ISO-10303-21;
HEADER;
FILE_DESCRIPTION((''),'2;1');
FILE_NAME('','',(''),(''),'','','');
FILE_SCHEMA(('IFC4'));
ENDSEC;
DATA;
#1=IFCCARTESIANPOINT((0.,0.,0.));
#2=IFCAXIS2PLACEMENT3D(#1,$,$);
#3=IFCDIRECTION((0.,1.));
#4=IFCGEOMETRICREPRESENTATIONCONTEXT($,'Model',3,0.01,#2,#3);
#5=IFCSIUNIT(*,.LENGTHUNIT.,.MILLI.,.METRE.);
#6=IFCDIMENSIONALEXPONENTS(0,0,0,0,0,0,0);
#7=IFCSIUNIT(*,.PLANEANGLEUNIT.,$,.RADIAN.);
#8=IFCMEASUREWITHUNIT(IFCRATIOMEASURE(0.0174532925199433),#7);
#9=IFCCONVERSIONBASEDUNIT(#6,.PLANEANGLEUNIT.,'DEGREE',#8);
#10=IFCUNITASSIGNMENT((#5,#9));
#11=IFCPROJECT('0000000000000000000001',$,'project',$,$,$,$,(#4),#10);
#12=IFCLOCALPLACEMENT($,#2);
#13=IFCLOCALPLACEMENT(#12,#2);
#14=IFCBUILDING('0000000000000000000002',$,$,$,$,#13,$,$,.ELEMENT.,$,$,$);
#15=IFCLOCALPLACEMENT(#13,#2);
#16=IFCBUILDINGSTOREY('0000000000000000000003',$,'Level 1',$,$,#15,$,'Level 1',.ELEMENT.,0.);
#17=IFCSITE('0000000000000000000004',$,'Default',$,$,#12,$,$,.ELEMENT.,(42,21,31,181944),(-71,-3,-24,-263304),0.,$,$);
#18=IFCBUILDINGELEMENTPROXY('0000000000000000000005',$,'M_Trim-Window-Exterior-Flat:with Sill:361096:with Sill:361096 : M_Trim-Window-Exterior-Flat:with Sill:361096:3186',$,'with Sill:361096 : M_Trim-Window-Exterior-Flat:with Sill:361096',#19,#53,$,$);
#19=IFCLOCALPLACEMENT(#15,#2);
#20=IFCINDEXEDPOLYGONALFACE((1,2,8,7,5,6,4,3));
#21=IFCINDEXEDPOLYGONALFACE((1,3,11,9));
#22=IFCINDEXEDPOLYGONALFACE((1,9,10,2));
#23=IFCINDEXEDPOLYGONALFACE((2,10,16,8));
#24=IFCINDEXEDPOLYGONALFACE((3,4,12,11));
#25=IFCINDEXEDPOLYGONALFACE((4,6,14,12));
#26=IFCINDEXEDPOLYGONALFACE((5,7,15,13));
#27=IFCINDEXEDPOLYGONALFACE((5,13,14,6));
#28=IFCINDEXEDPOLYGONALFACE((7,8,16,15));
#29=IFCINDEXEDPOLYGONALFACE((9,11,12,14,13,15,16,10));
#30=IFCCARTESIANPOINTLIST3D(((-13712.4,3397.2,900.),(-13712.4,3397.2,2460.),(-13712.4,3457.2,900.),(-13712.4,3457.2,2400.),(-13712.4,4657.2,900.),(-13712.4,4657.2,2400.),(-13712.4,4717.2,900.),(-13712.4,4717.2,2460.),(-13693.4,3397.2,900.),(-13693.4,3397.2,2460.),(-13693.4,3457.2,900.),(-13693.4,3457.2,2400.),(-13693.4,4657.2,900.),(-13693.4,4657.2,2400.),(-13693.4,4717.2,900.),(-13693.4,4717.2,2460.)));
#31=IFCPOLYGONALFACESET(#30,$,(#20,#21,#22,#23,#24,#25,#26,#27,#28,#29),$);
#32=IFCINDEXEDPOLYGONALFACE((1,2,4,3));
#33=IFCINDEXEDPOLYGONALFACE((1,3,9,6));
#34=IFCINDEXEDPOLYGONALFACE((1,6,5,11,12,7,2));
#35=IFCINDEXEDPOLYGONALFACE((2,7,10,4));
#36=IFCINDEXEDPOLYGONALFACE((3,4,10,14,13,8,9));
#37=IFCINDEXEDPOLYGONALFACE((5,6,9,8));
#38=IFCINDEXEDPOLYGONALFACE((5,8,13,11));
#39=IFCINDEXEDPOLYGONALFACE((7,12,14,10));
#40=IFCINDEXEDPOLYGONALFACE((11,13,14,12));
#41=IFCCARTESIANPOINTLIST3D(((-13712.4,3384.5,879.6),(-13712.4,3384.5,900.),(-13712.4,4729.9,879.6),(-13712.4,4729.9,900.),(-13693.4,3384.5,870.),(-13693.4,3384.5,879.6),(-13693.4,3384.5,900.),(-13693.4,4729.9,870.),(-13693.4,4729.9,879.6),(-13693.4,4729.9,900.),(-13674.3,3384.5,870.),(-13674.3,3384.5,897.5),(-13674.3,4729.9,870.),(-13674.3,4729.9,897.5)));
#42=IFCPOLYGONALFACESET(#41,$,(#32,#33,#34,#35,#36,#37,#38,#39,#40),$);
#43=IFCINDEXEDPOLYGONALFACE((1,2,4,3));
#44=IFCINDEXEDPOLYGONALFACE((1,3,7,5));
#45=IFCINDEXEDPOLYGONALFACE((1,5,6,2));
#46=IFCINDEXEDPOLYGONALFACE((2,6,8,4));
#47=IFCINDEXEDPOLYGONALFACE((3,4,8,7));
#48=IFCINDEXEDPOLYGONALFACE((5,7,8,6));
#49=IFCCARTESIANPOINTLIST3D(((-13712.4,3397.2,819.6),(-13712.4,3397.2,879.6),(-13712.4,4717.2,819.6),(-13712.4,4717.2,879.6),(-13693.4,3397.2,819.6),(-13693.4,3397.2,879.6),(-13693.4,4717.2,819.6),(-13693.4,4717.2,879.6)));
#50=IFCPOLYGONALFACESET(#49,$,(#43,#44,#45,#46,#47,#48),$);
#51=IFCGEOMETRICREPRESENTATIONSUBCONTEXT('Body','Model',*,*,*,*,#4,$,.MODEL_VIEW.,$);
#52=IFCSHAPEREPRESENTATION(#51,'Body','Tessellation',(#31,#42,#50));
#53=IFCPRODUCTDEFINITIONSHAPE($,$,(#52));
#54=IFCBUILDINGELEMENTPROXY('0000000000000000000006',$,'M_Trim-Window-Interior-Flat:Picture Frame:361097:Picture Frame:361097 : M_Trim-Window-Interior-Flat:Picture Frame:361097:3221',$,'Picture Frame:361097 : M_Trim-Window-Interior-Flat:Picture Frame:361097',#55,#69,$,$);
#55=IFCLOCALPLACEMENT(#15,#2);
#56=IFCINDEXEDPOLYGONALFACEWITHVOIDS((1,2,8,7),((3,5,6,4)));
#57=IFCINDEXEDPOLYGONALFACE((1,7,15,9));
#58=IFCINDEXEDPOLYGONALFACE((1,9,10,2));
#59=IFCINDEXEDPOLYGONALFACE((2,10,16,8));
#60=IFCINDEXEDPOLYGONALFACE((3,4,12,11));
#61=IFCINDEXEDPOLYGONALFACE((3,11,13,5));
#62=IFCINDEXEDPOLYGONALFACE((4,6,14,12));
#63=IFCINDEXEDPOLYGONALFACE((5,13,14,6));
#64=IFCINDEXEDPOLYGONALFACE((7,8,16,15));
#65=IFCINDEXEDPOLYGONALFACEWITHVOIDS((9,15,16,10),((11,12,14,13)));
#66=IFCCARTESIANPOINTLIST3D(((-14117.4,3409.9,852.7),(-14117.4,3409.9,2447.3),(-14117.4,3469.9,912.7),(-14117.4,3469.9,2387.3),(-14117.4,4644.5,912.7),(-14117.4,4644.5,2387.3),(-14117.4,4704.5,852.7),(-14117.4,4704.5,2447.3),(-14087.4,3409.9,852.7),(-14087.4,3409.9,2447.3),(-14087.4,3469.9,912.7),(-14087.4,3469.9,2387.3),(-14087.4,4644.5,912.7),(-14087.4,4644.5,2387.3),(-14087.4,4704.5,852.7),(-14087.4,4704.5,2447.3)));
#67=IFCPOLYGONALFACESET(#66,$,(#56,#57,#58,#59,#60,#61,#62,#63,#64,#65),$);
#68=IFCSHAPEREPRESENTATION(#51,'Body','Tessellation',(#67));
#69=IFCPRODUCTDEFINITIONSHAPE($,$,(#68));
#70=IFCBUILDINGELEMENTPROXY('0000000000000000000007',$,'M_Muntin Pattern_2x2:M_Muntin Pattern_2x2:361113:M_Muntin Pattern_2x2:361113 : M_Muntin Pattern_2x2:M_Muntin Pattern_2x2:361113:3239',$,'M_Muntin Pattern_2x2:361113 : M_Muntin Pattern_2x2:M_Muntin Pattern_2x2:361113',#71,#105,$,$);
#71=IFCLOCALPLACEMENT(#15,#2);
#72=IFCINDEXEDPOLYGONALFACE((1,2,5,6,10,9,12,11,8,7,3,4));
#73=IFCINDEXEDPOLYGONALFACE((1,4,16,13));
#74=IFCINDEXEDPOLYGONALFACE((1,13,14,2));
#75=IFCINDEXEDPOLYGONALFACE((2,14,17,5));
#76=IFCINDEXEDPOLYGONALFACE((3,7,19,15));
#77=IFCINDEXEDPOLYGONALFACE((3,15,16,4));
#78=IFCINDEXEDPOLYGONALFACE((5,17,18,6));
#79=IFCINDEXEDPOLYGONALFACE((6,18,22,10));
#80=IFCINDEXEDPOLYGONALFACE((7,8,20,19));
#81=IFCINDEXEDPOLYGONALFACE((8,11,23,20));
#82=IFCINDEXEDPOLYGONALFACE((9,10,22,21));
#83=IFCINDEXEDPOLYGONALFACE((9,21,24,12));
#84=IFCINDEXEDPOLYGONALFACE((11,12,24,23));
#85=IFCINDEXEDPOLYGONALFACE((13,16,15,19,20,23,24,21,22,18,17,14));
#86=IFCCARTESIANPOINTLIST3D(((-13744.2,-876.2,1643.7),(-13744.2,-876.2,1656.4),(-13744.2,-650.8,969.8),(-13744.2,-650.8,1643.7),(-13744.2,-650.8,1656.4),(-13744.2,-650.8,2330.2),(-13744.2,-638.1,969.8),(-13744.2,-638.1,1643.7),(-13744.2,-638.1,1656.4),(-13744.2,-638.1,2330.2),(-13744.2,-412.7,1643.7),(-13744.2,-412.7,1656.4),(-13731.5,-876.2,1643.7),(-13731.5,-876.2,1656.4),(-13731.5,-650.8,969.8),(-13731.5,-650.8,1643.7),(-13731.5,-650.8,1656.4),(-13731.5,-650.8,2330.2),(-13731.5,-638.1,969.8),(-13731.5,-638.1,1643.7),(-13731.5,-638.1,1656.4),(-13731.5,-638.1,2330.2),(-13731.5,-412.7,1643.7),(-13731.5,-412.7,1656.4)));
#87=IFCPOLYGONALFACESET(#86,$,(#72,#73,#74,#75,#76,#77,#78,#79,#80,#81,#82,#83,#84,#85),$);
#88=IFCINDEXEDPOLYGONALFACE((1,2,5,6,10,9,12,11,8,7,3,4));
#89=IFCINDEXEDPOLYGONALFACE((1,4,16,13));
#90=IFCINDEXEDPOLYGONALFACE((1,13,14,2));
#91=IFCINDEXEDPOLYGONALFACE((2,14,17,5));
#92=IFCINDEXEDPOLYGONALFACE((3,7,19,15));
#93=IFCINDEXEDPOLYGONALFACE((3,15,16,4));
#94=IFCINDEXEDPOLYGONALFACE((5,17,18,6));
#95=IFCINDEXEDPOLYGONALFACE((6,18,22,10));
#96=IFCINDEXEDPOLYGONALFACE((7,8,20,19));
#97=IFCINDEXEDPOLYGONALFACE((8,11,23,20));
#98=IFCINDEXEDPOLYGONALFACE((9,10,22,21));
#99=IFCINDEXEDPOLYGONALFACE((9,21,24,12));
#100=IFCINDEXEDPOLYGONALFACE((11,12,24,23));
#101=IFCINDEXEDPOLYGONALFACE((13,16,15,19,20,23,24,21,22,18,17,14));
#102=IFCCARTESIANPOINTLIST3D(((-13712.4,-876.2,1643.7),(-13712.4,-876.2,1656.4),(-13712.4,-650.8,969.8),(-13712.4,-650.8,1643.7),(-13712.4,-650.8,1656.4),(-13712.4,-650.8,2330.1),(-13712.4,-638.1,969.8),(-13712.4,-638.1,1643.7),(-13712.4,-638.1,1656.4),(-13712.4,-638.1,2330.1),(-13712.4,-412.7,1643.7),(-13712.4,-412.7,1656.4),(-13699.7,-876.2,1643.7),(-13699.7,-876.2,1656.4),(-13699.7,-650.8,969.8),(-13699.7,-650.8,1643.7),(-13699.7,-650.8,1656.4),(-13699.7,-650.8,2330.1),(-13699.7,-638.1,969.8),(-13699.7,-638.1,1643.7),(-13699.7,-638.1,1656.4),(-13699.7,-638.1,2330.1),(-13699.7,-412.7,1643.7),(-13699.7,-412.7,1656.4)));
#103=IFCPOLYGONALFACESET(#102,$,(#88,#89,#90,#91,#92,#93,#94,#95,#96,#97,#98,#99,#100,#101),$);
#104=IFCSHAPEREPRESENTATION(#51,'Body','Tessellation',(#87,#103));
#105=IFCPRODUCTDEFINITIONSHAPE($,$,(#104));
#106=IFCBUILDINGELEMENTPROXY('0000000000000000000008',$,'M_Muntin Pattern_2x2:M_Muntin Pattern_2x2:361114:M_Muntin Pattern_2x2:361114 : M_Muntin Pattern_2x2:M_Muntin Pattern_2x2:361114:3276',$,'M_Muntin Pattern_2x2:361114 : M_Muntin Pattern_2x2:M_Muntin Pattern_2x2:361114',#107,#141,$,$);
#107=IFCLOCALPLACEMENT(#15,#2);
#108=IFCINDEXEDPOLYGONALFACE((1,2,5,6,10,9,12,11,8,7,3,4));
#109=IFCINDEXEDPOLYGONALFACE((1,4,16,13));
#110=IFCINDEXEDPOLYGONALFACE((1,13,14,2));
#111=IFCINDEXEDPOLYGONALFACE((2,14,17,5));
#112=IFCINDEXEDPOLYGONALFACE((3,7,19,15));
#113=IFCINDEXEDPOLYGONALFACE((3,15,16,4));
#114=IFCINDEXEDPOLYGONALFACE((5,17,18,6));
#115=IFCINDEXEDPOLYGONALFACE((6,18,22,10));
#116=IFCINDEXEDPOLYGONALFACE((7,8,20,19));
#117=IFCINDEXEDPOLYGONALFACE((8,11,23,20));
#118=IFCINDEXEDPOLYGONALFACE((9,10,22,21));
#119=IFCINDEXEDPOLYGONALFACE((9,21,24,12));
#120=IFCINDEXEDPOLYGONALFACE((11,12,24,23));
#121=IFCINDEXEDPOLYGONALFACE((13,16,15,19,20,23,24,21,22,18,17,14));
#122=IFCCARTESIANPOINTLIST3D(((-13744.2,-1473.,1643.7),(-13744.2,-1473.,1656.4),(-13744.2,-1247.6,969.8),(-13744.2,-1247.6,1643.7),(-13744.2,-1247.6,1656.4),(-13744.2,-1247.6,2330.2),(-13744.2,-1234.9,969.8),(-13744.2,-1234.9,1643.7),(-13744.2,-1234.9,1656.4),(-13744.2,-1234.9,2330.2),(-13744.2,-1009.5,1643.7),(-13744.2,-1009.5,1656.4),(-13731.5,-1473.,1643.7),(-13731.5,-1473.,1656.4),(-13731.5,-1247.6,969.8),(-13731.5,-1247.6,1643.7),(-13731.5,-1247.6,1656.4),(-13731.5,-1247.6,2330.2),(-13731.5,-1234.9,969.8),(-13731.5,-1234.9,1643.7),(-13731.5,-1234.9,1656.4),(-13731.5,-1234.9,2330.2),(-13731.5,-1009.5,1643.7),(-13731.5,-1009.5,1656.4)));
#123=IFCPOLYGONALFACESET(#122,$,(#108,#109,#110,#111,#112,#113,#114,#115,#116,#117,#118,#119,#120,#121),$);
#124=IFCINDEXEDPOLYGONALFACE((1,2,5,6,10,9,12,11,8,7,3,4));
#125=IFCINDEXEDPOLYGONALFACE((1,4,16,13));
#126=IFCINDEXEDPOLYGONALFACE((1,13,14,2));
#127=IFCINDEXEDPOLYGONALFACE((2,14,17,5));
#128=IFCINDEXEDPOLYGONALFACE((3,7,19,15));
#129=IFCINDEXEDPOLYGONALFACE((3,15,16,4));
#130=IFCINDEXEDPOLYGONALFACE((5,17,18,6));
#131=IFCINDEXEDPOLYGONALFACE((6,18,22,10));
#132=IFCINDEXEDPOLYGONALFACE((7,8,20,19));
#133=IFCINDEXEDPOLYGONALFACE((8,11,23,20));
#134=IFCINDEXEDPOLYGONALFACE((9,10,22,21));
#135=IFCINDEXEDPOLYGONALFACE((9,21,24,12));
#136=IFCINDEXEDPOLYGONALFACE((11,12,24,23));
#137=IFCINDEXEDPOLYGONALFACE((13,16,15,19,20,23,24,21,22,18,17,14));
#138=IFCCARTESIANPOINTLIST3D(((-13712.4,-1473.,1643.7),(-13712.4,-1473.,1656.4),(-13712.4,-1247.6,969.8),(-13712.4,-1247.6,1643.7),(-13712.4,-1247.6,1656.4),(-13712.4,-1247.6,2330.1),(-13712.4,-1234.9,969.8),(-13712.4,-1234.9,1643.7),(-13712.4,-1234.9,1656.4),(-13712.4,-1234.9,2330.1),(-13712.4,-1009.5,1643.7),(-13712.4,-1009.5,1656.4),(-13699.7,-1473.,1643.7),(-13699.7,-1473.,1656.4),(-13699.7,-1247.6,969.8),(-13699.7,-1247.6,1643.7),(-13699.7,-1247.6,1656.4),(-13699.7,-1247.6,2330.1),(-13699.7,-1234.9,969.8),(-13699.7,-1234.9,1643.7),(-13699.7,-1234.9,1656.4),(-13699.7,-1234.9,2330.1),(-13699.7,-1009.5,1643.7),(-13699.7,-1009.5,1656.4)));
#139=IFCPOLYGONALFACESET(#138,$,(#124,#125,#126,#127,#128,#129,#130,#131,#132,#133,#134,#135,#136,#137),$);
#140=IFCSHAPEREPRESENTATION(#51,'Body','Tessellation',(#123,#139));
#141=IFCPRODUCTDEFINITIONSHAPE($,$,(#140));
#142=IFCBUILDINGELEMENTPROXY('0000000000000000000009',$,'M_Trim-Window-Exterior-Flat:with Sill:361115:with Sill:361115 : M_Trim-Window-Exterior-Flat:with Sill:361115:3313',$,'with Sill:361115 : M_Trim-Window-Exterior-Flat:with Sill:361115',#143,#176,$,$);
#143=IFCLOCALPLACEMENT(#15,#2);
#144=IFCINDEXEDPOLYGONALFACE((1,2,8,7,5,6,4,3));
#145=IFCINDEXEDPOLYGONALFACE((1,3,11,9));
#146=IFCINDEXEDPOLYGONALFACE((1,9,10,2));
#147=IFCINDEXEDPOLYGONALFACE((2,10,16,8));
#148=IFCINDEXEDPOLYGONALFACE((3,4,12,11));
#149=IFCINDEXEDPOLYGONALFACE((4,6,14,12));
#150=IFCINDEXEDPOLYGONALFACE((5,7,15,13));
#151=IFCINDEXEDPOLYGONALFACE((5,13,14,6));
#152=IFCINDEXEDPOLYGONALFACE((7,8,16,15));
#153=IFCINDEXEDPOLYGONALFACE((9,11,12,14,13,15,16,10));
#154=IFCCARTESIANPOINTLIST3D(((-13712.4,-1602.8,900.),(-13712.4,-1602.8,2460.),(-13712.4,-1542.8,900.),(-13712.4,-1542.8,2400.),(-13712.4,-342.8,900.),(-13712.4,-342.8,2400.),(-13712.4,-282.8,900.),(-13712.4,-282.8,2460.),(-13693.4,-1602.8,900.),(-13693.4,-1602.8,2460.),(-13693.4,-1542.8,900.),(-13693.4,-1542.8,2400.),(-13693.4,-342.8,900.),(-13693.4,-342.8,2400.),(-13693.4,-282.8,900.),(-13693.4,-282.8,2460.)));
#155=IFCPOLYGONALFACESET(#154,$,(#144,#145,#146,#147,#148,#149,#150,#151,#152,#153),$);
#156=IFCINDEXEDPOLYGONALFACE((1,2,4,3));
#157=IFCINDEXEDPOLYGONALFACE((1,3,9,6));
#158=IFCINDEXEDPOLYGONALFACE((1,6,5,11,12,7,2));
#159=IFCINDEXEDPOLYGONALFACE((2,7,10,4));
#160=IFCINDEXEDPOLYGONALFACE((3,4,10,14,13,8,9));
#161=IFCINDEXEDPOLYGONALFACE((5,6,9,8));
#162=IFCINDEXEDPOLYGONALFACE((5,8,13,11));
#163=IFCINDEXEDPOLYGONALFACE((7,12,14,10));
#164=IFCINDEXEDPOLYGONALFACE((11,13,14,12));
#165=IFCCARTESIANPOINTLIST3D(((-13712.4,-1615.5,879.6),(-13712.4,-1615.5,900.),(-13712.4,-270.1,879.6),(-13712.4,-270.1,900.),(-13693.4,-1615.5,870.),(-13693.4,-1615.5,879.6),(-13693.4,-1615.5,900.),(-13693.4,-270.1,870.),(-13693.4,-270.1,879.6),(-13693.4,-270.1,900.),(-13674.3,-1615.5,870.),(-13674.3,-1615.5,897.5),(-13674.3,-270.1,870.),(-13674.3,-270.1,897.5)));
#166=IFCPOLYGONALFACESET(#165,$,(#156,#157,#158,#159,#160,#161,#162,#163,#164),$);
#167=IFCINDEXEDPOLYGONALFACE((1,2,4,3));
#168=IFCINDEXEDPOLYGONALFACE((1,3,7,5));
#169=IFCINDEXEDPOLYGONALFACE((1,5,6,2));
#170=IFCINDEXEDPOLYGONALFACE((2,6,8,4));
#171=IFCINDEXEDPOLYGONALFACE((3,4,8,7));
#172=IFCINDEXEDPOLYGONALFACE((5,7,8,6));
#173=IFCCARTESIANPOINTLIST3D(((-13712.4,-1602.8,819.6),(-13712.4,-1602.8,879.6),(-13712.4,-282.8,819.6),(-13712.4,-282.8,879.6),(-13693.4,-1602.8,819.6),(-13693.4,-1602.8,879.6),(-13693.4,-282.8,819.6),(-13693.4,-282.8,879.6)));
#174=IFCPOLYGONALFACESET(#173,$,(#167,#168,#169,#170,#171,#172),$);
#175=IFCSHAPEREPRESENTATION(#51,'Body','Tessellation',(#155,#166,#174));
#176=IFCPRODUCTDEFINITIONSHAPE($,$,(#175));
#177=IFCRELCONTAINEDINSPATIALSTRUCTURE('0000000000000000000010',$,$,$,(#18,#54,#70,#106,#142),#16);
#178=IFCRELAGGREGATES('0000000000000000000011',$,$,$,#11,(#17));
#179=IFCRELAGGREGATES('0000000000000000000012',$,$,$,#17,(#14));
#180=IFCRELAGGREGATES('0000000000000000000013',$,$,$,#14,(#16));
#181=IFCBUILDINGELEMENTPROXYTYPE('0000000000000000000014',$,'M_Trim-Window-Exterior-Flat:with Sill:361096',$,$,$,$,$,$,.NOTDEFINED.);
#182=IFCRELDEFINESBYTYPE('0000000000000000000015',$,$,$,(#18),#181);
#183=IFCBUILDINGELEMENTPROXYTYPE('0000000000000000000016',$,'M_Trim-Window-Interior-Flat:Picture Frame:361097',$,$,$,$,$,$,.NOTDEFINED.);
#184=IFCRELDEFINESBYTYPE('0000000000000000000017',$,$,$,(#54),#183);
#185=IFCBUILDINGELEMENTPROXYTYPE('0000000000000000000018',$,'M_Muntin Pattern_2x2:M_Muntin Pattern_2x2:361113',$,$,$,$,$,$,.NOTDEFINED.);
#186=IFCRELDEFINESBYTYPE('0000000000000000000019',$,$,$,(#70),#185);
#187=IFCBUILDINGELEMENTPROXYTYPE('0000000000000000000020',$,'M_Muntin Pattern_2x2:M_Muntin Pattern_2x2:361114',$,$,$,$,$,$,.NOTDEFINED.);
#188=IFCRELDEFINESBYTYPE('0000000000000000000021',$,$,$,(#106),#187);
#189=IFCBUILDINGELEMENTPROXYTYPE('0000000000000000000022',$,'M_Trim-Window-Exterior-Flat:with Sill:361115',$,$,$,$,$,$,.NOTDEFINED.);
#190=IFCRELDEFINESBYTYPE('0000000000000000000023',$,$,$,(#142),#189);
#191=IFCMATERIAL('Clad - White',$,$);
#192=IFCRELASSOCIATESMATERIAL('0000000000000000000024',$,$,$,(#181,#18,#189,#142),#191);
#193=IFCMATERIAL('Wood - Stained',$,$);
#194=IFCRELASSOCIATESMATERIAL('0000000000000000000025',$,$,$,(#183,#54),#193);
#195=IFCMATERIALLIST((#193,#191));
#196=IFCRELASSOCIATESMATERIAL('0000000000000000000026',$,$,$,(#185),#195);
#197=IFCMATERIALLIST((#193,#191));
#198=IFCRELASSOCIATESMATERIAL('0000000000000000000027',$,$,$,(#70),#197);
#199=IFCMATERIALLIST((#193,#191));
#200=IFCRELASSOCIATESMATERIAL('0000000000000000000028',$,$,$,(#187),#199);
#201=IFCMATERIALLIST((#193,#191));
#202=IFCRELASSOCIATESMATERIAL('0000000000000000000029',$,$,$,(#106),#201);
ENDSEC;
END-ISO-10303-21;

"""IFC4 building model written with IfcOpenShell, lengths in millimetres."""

from ifc_helpers import new_model, entity, si_unit, converted_unit, direction, frame, frame_2d, origin, origin_2d_with_axis, place, context, subcontext, project, spatial, polyline, rectangle, outline, extrude, source, transform, mapped, material, material_list, type_object, type_shapes, element, save


model = new_model("IFC4")

# Units and contexts
model_context = context("Model", 3, precision=0.01, world=origin(), true_north=direction((0.0, 1.0)))
body_context = subcontext(model_context, "Body", "Model", "MODEL_VIEW")
ifc_project = project(units=[si_unit("LENGTHUNIT", "METRE", prefix="MILLI"), converted_unit("PLANEANGLEUNIT", "DEGREE", entity("IfcRatioMeasure", 0.0174532925199433), si_unit("PLANEANGLEUNIT", "RADIAN"), dimensions=[0, 0, 0, 0, 0, 0, 0])], contexts=[model_context])

# Site, building, storey
site_placement = place(None, origin())
site = spatial("IfcSite", under=ifc_project, at=site_placement, Name="Default", CompositionType="ELEMENT", RefLatitude=(42, 21, 31, 181944), RefLongitude=(-71, -3, -24, -263304), RefElevation=0.0)
building_placement = place(site_placement, origin())
building = spatial("IfcBuilding", under=site, at=building_placement, CompositionType="ELEMENT")
storey_placement = place(building_placement, origin())
storey = spatial("IfcBuildingStorey", under=building, at=storey_placement, Name="Level 1", LongName="Level 1", CompositionType="ELEMENT", Elevation=0.0)

# Building element proxies
ifc_material_1 = material(Name="Wood - Stained")
ifc_material_2 = material(Name="Clad - White")
building_element_proxy_type_1 = type_object("IfcBuildingElementProxyType", Name="M_Trim-Window-Exterior-Flat:with Sill:361096", PredefinedType="NOTDEFINED", material=ifc_material_2)
shared_shape_1 = source(origin(), body_context, "Body", "SweptSolid", [
    extrude(outline(polyline([(-660.0, -765.0), (-600.0, -765.0), (-600.0, 735.0), (600.0, 735.0), (600.0, -765.0), (660.0, -765.0), (660.0, 795.0), (-660.0, 795.0), (-660.0, -765.0)])), frame((-13712.4, 4057.2, 1665.0), z_axis=(1.0, 0.0, 0.0), x_axis=(0.0, 1.0, 0.0)), (0.0, 0.0, 1.0), 19.1),
    extrude(outline(polyline([(-15.2, 0.0), (-15.2, -19.0), (12.3, -19.0), (14.8, 0.0), (14.8, 19.0), (-5.7, 19.0), (-5.7, 0.0), (-15.2, 0.0)])), frame((-13693.4, 3384.5, 885.2), z_axis=(0.0, -1.0, 0.0), x_axis=(0.0, 0.0, 1.0)), (0.0, 0.0, -1.0), 1345.4),
    extrude(rectangle(XDim=19.1, YDim=1320.0, at=frame_2d((0.0, 0.0), x_axis=(1.0, 0.0))), frame((-13702.9, 4057.2, 819.6), z_axis=(0.0, 0.0, 1.0), x_axis=(-1.0, 0.0, 0.0)), (0.0, 0.0, 1.0), 60.0),
])
type_shapes(building_element_proxy_type_1, [shared_shape_1])
proxy_1_placement = place(storey_placement, origin())
element("IfcBuildingElementProxy", 1, at=proxy_1_placement, inside=storey, type_object=building_element_proxy_type_1, material=ifc_material_2, Name="M_Trim-Window-Exterior-Flat:with Sill:361096:with Sill:361096 : M_Trim-Window-Exterior-Flat:with Sill:361096:3186", ObjectType="with Sill:361096 : M_Trim-Window-Exterior-Flat:with Sill:361096", context=body_context, shape_type="MappedRepresentation", body=[
    mapped(shared_shape_1, transform((0.0, 0.0, 0.0), scale=1.0)),
])
building_element_proxy_type_2 = type_object("IfcBuildingElementProxyType", Name="M_Trim-Window-Interior-Flat:Picture Frame:361097", PredefinedType="NOTDEFINED", material=ifc_material_1)
shared_shape_2 = source(origin(), body_context, "Body", "SweptSolid", [
    extrude(outline(polyline([(-647.3, -797.3), (647.3, -797.3), (647.3, 797.3), (-647.3, 797.3), (-647.3, -797.3)]), holes=[polyline([(587.3, 737.3), (587.3, -737.3), (-587.3, -737.3), (-587.3, 737.3), (587.3, 737.3)])]), frame((-14117.4, 4057.2, 1650.0), z_axis=(1.0, 0.0, 0.0), x_axis=(0.0, -1.0, 0.0)), (0.0, 0.0, 1.0), 30.0),
])
type_shapes(building_element_proxy_type_2, [shared_shape_2])
proxy_2_placement = place(storey_placement, origin())
element("IfcBuildingElementProxy", 2, at=proxy_2_placement, inside=storey, type_object=building_element_proxy_type_2, material=ifc_material_1, Name="M_Trim-Window-Interior-Flat:Picture Frame:361097:Picture Frame:361097 : M_Trim-Window-Interior-Flat:Picture Frame:361097:3221", ObjectType="Picture Frame:361097 : M_Trim-Window-Interior-Flat:Picture Frame:361097", context=body_context, shape_type="MappedRepresentation", body=[
    mapped(shared_shape_2, transform((0.0, 0.0, 0.0), scale=1.0)),
])
ifc_material_list_1 = material_list([ifc_material_1, ifc_material_2])
ifc_material_list_2 = material_list([ifc_material_1, ifc_material_2])
building_element_proxy_type_3 = type_object("IfcBuildingElementProxyType", Name="M_Muntin Pattern_2x2:M_Muntin Pattern_2x2:361113", PredefinedType="NOTDEFINED", material=ifc_material_list_2)
shared_shape_3 = source(origin(), body_context, "Body", "SweptSolid", [
    extrude(outline(polyline([(-6.4, -680.2), (6.3, -680.2), (6.3, -6.4), (231.7, -6.4), (231.7, 6.3), (6.3, 6.3), (6.3, 680.2), (-6.4, 680.2), (-6.4, 6.3), (-231.7, 6.3), (-231.7, -6.4), (-6.4, -6.4), (-6.4, -680.2)])), frame((-13744.2, -644.4, 1650.0), z_axis=(1.0, 0.0, 0.0), x_axis=(0.0, -1.0, 0.0)), (0.0, 0.0, 1.0), 12.7),
    extrude(outline(polyline([(-6.4, -680.1), (6.3, -680.1), (6.3, -6.4), (231.7, -6.4), (231.7, 6.3), (6.3, 6.3), (6.3, 680.2), (-6.4, 680.2), (-6.4, 6.3), (-231.7, 6.3), (-231.7, -6.4), (-6.4, -6.4), (-6.4, -680.1)])), frame((-13712.4, -644.4, 1650.0), z_axis=(1.0, 0.0, 0.0), x_axis=(0.0, -1.0, 0.0)), (0.0, 0.0, 1.0), 12.7),
])
type_shapes(building_element_proxy_type_3, [shared_shape_3])
proxy_3_placement = place(storey_placement, origin())
element("IfcBuildingElementProxy", 3, at=proxy_3_placement, inside=storey, type_object=building_element_proxy_type_3, material=ifc_material_list_1, Name="M_Muntin Pattern_2x2:M_Muntin Pattern_2x2:361113:M_Muntin Pattern_2x2:361113 : M_Muntin Pattern_2x2:M_Muntin Pattern_2x2:361113:3239", ObjectType="M_Muntin Pattern_2x2:361113 : M_Muntin Pattern_2x2:M_Muntin Pattern_2x2:361113", context=body_context, shape_type="MappedRepresentation", body=[
    mapped(shared_shape_3, transform((0.0, 0.0, 0.0), scale=1.0)),
])
ifc_material_list_3 = material_list([ifc_material_1, ifc_material_2])
ifc_material_list_4 = material_list([ifc_material_1, ifc_material_2])
building_element_proxy_type_4 = type_object("IfcBuildingElementProxyType", Name="M_Muntin Pattern_2x2:M_Muntin Pattern_2x2:361114", PredefinedType="NOTDEFINED", material=ifc_material_list_4)
shared_shape_4 = source(origin(), body_context, "Body", "SweptSolid", [
    extrude(outline(polyline([(-680.1, 6.4), (-680.1, -6.3), (-6.4, -6.3), (-6.4, -231.7), (6.3, -231.7), (6.3, -6.3), (680.2, -6.3), (680.2, 6.4), (6.3, 6.4), (6.3, 231.7), (-6.4, 231.7), (-6.4, 6.4), (-680.1, 6.4)])), frame((-13744.2, -1241.3, 1650.0), z_axis=(-1.0, 0.0, 0.0), x_axis=(0.0, 0.0, -1.0)), (0.0, 0.0, -1.0), 12.7),
    extrude(outline(polyline([(-680.1, 6.4), (-680.1, -6.3), (-6.4, -6.3), (-6.4, -231.7), (6.3, -231.7), (6.3, -6.3), (680.2, -6.3), (680.2, 6.4), (6.3, 6.4), (6.3, 231.7), (-6.4, 231.7), (-6.4, 6.4), (-680.1, 6.4)])), frame((-13712.4, -1241.3, 1650.0), z_axis=(-1.0, 0.0, 0.0), x_axis=(0.0, 0.0, -1.0)), (0.0, 0.0, -1.0), 12.7),
])
type_shapes(building_element_proxy_type_4, [shared_shape_4])
proxy_4_placement = place(storey_placement, origin())
element("IfcBuildingElementProxy", 4, at=proxy_4_placement, inside=storey, type_object=building_element_proxy_type_4, material=ifc_material_list_3, Name="M_Muntin Pattern_2x2:M_Muntin Pattern_2x2:361114:M_Muntin Pattern_2x2:361114 : M_Muntin Pattern_2x2:M_Muntin Pattern_2x2:361114:3276", ObjectType="M_Muntin Pattern_2x2:361114 : M_Muntin Pattern_2x2:M_Muntin Pattern_2x2:361114", context=body_context, shape_type="MappedRepresentation", body=[
    mapped(shared_shape_4, transform((0.0, 0.0, 0.0), scale=1.0)),
])
building_element_proxy_type_5 = type_object("IfcBuildingElementProxyType", Name="M_Trim-Window-Exterior-Flat:with Sill:361115", PredefinedType="NOTDEFINED", material=ifc_material_2)
shared_shape_5 = source(origin(), body_context, "Body", "SweptSolid", [
    extrude(outline(polyline([(-660.0, -765.0), (-600.0, -765.0), (-600.0, 735.0), (600.0, 735.0), (600.0, -765.0), (660.0, -765.0), (660.0, 795.0), (-660.0, 795.0), (-660.0, -765.0)])), frame((-13712.4, -942.8, 1665.0), z_axis=(1.0, 0.0, 0.0), x_axis=(0.0, 1.0, 0.0)), (0.0, 0.0, 1.0), 19.1),
    extrude(outline(polyline([(-15.2, 0.0), (-15.2, -19.0), (12.3, -19.0), (14.8, 0.0), (14.8, 19.0), (-5.7, 19.0), (-5.7, 0.0), (-15.2, 0.0)])), frame((-13693.4, -1615.5, 885.2), z_axis=(0.0, -1.0, 0.0), x_axis=(0.0, 0.0, 1.0)), (0.0, 0.0, -1.0), 1345.4),
    extrude(rectangle(XDim=19.1, YDim=1320.0, at=origin_2d_with_axis()), frame((-13702.9, -942.8, 819.6), z_axis=(0.0, 0.0, 1.0), x_axis=(-1.0, 0.0, 0.0)), (0.0, 0.0, 1.0), 60.0),
])
type_shapes(building_element_proxy_type_5, [shared_shape_5])
proxy_5_placement = place(storey_placement, origin())
element("IfcBuildingElementProxy", 5, at=proxy_5_placement, inside=storey, type_object=building_element_proxy_type_5, material=ifc_material_2, Name="M_Trim-Window-Exterior-Flat:with Sill:361115:with Sill:361115 : M_Trim-Window-Exterior-Flat:with Sill:361115:3313", ObjectType="with Sill:361115 : M_Trim-Window-Exterior-Flat:with Sill:361115", context=body_context, shape_type="MappedRepresentation", body=[
    mapped(shared_shape_5, transform((0.0, 0.0, 0.0), scale=1.0)),
])

save(model, "model.ifc")
